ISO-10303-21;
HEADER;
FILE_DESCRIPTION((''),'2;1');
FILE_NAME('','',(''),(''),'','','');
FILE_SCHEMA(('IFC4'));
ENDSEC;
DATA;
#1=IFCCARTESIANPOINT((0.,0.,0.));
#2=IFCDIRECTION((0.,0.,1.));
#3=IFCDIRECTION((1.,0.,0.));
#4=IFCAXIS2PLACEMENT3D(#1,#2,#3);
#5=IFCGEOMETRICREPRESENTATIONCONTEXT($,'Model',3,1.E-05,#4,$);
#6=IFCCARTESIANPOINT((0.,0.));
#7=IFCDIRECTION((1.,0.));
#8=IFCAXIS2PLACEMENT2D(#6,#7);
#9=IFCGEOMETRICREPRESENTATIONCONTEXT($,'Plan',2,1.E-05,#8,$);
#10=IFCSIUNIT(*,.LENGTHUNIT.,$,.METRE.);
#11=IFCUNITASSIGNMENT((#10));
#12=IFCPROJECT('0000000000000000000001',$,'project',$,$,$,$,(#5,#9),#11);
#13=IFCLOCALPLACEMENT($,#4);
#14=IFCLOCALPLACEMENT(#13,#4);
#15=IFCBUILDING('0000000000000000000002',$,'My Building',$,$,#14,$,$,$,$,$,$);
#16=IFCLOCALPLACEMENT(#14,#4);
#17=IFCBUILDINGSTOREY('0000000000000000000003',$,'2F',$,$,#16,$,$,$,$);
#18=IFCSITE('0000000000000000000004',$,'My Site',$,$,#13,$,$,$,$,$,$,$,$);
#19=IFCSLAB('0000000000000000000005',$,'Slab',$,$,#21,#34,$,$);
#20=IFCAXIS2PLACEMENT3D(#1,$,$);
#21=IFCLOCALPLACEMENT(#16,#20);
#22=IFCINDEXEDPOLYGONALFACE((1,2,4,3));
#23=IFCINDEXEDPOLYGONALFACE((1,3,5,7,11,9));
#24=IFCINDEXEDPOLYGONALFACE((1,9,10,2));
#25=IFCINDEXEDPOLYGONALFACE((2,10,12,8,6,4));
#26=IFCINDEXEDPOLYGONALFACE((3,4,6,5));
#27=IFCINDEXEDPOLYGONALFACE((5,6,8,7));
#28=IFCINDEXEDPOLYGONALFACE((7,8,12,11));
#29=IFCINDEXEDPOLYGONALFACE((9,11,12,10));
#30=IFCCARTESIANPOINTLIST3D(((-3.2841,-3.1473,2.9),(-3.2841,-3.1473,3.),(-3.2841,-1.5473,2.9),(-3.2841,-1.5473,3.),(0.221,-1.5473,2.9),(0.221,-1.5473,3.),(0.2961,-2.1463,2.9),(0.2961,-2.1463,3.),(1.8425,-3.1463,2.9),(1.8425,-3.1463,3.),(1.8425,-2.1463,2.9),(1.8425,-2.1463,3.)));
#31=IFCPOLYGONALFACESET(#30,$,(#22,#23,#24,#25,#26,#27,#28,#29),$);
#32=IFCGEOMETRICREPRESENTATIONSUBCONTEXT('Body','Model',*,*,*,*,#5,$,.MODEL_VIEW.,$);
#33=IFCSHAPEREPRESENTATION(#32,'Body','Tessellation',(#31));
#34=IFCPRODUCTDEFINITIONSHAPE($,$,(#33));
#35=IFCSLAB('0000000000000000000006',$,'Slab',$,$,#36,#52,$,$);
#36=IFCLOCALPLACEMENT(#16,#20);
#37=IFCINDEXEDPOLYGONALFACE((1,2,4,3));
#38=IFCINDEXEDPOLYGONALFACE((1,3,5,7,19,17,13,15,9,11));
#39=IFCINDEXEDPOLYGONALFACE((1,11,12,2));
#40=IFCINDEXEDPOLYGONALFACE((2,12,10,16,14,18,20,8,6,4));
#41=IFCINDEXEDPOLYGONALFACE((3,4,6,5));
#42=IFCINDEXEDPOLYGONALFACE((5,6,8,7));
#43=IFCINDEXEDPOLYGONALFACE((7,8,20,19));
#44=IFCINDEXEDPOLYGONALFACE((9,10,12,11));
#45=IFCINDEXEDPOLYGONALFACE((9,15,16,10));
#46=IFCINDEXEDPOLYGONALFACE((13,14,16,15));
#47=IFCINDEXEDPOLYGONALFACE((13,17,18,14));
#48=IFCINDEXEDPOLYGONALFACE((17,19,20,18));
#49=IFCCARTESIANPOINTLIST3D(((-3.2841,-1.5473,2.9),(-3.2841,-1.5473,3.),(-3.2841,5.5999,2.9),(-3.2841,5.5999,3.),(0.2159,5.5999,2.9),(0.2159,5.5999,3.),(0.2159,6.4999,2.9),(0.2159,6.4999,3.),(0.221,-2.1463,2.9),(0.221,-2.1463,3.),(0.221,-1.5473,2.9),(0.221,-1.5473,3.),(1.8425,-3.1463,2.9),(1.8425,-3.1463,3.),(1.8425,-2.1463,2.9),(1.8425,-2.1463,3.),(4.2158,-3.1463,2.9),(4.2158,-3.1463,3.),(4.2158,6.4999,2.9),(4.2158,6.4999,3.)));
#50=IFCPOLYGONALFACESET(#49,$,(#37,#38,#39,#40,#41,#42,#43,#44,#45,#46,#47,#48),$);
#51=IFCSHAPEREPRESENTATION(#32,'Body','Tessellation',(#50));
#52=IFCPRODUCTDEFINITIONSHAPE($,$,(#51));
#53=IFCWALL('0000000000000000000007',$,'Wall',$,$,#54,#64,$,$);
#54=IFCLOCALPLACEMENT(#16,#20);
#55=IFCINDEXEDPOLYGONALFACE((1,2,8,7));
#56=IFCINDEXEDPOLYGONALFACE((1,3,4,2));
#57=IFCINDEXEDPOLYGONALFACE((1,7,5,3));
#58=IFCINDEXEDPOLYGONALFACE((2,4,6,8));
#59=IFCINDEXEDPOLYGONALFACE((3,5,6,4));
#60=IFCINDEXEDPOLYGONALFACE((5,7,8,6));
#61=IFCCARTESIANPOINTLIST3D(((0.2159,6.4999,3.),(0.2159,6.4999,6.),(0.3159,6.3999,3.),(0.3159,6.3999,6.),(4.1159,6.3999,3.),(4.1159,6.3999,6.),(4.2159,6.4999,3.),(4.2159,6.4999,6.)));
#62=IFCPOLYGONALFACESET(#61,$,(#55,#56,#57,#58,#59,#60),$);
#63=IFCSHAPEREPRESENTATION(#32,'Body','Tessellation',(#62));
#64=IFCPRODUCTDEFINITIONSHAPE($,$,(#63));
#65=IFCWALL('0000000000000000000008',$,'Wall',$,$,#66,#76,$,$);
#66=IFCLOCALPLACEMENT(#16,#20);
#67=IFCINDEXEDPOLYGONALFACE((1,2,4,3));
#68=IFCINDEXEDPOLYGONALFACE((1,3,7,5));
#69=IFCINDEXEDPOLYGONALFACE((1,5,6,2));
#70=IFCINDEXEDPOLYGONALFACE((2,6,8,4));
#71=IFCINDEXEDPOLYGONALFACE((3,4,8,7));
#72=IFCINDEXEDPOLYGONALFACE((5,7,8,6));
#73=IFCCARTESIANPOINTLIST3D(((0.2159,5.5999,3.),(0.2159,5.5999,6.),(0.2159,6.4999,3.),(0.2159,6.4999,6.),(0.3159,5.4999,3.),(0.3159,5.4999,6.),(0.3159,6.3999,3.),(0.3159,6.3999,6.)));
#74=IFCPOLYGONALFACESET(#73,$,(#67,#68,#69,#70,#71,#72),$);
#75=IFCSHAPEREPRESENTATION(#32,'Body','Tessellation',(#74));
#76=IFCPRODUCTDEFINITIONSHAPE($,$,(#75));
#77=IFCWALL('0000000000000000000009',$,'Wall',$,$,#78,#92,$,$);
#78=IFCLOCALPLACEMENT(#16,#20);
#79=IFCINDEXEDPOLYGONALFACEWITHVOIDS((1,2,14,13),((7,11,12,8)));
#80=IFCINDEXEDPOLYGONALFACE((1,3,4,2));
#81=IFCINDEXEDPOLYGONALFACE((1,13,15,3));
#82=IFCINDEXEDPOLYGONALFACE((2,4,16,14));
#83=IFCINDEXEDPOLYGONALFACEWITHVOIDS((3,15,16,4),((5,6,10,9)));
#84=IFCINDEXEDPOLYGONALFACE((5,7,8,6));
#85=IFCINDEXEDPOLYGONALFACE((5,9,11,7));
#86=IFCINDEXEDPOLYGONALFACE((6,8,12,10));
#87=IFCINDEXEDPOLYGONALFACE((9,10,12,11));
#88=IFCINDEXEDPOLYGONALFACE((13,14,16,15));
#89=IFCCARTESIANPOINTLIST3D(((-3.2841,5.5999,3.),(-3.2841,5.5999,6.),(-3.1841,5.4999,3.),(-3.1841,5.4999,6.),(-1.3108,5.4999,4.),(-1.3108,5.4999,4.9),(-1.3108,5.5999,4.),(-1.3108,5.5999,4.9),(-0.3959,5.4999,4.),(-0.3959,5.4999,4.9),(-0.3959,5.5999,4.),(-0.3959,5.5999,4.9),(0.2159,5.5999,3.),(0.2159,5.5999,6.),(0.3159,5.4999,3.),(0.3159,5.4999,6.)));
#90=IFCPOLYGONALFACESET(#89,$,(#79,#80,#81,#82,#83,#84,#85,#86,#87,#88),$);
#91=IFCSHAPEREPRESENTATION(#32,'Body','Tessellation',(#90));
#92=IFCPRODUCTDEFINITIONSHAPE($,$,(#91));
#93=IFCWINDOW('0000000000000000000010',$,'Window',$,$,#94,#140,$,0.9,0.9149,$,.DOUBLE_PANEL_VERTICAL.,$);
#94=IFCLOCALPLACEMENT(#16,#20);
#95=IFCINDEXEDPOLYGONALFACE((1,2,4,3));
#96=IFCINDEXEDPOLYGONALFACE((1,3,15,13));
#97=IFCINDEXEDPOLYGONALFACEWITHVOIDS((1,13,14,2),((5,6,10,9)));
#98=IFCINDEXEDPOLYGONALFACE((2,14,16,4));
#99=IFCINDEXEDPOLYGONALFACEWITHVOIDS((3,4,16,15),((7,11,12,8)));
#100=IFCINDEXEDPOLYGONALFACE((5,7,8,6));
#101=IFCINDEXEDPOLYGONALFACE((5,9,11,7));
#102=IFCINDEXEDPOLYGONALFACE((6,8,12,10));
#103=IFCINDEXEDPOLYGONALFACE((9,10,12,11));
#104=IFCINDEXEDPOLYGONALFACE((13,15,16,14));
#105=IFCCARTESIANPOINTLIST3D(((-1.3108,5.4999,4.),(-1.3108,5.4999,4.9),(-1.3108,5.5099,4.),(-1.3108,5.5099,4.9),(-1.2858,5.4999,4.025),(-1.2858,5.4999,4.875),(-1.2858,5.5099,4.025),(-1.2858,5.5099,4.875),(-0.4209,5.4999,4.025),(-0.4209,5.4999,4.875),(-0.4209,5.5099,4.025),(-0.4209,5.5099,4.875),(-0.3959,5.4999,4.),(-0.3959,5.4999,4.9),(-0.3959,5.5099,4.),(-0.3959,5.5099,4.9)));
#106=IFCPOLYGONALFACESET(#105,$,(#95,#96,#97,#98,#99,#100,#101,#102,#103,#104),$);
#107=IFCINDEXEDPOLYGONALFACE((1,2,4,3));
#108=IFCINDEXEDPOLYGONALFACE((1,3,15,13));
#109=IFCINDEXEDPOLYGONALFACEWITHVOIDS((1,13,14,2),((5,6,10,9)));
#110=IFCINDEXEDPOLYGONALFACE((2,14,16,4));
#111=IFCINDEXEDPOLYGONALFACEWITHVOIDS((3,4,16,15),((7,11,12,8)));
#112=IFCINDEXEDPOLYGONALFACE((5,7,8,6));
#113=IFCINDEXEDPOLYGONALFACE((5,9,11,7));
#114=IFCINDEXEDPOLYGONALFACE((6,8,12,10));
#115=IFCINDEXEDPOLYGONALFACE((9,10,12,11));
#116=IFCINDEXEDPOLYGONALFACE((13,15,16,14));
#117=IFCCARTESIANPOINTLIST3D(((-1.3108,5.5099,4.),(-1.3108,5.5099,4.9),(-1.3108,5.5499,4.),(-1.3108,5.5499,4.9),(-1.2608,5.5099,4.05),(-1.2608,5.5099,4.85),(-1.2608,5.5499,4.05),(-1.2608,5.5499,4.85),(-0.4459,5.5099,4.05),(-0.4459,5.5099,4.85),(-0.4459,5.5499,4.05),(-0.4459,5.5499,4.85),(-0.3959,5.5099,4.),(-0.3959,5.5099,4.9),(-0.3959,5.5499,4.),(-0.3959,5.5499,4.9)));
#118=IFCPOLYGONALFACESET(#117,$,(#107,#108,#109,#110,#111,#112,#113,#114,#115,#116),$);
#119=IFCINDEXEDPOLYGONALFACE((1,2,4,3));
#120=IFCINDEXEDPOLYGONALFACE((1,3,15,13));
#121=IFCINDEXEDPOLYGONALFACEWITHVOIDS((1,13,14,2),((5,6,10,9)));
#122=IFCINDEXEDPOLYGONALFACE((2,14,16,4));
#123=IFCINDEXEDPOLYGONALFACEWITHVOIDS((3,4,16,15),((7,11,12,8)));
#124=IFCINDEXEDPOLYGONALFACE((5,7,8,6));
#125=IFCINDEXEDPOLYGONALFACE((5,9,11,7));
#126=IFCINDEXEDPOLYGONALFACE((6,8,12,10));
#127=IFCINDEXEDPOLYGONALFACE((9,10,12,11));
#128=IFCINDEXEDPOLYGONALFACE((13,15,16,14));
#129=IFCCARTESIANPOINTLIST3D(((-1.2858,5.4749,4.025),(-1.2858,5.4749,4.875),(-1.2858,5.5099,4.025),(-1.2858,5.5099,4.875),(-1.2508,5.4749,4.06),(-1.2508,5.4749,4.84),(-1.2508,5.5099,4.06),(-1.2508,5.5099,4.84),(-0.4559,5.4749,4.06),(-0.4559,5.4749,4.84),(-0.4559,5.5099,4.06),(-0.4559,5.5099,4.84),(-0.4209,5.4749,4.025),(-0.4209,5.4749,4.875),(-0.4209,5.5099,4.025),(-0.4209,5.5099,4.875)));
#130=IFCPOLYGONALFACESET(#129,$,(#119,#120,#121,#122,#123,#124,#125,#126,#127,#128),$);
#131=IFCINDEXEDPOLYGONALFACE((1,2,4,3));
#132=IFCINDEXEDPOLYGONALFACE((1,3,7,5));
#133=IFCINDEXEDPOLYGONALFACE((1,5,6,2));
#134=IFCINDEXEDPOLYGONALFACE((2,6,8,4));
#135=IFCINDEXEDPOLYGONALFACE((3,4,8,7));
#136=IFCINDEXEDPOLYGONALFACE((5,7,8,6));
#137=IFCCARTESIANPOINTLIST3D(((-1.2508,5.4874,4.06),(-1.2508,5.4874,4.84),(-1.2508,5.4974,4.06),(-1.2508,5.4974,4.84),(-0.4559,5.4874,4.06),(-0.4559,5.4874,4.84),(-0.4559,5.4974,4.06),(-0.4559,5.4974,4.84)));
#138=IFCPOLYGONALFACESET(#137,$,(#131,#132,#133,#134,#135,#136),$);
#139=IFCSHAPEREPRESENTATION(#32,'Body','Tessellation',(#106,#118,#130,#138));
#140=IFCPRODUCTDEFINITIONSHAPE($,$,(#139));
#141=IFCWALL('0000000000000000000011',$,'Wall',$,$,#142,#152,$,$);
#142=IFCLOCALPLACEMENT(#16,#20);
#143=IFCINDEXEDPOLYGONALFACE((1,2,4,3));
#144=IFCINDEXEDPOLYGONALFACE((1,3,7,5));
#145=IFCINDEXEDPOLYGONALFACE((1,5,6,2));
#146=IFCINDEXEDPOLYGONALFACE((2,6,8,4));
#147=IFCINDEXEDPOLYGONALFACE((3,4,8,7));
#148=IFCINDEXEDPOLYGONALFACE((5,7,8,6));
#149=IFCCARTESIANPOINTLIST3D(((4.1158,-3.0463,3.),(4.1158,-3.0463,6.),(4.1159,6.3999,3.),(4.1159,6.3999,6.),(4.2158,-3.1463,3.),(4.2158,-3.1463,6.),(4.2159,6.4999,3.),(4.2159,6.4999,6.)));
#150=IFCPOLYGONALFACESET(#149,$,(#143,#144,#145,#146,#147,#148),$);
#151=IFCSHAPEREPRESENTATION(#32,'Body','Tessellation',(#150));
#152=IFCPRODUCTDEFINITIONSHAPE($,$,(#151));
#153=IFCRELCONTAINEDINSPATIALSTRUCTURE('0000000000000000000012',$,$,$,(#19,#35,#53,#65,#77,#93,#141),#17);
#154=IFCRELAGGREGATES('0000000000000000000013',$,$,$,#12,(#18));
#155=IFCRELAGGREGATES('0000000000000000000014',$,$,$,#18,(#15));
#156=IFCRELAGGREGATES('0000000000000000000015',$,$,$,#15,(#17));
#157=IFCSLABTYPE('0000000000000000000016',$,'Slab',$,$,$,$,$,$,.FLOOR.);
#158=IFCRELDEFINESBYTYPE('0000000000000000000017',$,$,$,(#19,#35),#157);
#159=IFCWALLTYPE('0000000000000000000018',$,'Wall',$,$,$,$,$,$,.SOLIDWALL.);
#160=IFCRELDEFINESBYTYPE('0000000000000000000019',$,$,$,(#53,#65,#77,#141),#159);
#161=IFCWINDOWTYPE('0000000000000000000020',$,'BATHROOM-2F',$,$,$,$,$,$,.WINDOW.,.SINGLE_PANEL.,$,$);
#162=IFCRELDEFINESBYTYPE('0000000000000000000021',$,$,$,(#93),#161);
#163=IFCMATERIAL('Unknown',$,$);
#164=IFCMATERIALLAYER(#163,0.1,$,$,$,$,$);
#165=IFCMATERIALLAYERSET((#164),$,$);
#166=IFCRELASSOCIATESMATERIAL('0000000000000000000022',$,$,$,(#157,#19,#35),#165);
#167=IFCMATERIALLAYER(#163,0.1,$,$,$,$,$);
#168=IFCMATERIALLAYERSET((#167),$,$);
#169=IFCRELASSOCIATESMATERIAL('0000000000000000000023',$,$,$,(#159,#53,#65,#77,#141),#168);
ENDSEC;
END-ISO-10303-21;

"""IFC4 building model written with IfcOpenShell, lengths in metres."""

from ifc_helpers import new_model, entity, si_unit, frame, origin_with_axes, origin_2d_with_axis, place, context, subcontext, project, spatial, line, indexed_curve, outline, extrude, shape, source, transform, mapped, material, layer, layer_set, layer_usage, type_object, type_shapes, element, fill, save


model = new_model("IFC4")

# Units and contexts
model_context = context("Model", 3, precision=1e-05, world=origin_with_axes())
plan_context = context("Plan", 2, precision=1e-05, world=origin_2d_with_axis())
body_context_1 = subcontext(model_context, "Body", "Model", "MODEL_VIEW")
body_context_2 = subcontext(plan_context, "Body", "Plan", "PLAN_VIEW")
ifc_project = project(units=[si_unit("LENGTHUNIT", "METRE")], contexts=[model_context, plan_context])

# Site, building, storey
site_placement = place(None, origin_with_axes())
site = spatial("IfcSite", under=ifc_project, at=site_placement, Name="My Site")
building_placement = place(site_placement, origin_with_axes())
building = spatial("IfcBuilding", under=site, at=building_placement, Name="My Building")
storey_placement = place(building_placement, origin_with_axes())
storey = spatial("IfcBuildingStorey", under=building, at=storey_placement, Name="2F")

# Slabs
ifc_material = material(Name="Unknown")
ifc_layer_1 = layer(ifc_material, 0.1)
ifc_layer_set_1 = layer_set([ifc_layer_1])
ifc_layer_usage_1 = layer_usage(ifc_layer_set_1, "AXIS3", "POSITIVE", -0.1)
slab_type = type_object("IfcSlabType", Name="Slab", PredefinedType="FLOOR", material=ifc_layer_set_1)
slab_1_placement = place(storey_placement, frame((-3.2841, -1.5473, 3.0), z_axis=(0.0, 0.0, 1.0), x_axis=(1.0, 0.0, 0.0)))
element("IfcSlab", 1, at=slab_1_placement, inside=storey, type_object=slab_type, material=ifc_layer_usage_1, Name="Slab", context=body_context_1, shape_type="SweptSolid", body=[
    extrude(outline(indexed_curve([(0.0, 0.0), (0.0, -1.6), (5.1266, -1.599), (5.1266, -0.599), (3.5803, -0.599), (3.5052, 0.0), (0.0, 0.0)])), frame((0.0, 0.0, -0.1), z_axis=(0.0, 0.0, 1.0), x_axis=(1.0, 0.0, 0.0)), (0.0, 0.0, 1.0), 0.1),
])
ifc_layer_usage_2 = layer_usage(ifc_layer_set_1, "AXIS3", "POSITIVE", -0.1)
slab_2_placement = place(storey_placement, frame((4.2158, 6.4999, 3.0), z_axis=(0.0, 0.0, 1.0), x_axis=(1.0, 0.0, 0.0)))
element("IfcSlab", 2, at=slab_2_placement, inside=storey, type_object=slab_type, material=ifc_layer_usage_2, Name="Slab", context=body_context_1, shape_type="SweptSolid", body=[
    extrude(outline(indexed_curve([(0.0, 0.0), (-4.0, 0.0), (-4.0, -0.9), (-7.5, -0.9), (-7.5, -8.0471), (-3.9948, -8.0471), (-3.9948, -8.6461), (-2.3734, -8.6461), (-2.3734, -9.6461), (0.0, -9.6461), (0.0, 0.0)])), frame((0.0, 0.0, -0.1), z_axis=(0.0, 0.0, 1.0), x_axis=(1.0, 0.0, 0.0)), (0.0, 0.0, 1.0), 0.1),
])

# Walls
ifc_layer_2 = layer(ifc_material, 0.1)
ifc_layer_set_2 = layer_set([ifc_layer_2])
ifc_layer_usage_3 = layer_usage(ifc_layer_set_2, "AXIS2", "POSITIVE", 0.0)
wall_type = type_object("IfcWallType", Name="Wall", PredefinedType="SOLIDWALL", material=ifc_layer_set_2)
wall_1_placement = place(storey_placement, frame((4.2159, 6.4999, 3.0), z_axis=(0.0, 0.0, 1.0), x_axis=(-1.0, 0.0, 0.0)))
element("IfcWall", 3, at=wall_1_placement, inside=storey, type_object=wall_type, material=ifc_layer_usage_3, Name="Wall", context=body_context_1, shape_type="SweptSolid", body=[
    extrude(outline(indexed_curve([(0.0, 0.0), (0.1, 0.1), (3.9, 0.1), (4.0, 0.0)], segments=[line(1, 2, 3, 4, 1)])), origin_with_axes(), (0.0, 0.0, 1.0), 3.0),
])
ifc_layer_usage_4 = layer_usage(ifc_layer_set_2, "AXIS2", "POSITIVE", 0.0)
wall_2_placement = place(storey_placement, frame((0.2159, 6.4999, 3.0), z_axis=(0.0, 0.0, 1.0), x_axis=(0.0, -1.0, 0.0)))
element("IfcWall", 4, at=wall_2_placement, inside=storey, type_object=wall_type, material=ifc_layer_usage_4, Name="Wall", context=body_context_1, shape_type="SweptSolid", body=[
    extrude(outline(indexed_curve([(0.0, 0.0), (0.1, 0.1), (1.0, 0.1), (0.9, 0.0)], segments=[line(1, 2, 3, 4, 1)])), origin_with_axes(), (0.0, 0.0, 1.0), 3.0),
])

# Wall, opening, window
ifc_layer_usage_5 = layer_usage(ifc_layer_set_2, "AXIS2", "POSITIVE", 0.0)
wall_3_placement = place(storey_placement, frame((0.2159, 5.5999, 3.0), z_axis=(0.0, 0.0, 1.0), x_axis=(-1.0, 0.0, 0.0)))
wall_3 = element("IfcWall", 5, at=wall_3_placement, inside=storey, type_object=wall_type, material=ifc_layer_usage_5, Name="Wall", context=body_context_1, shape_type="SweptSolid", body=[
    extrude(outline(indexed_curve([(0.0, 0.0), (-0.1, 0.1), (3.4, 0.1), (3.5, 0.0)], segments=[line(1, 2, 3, 4, 1)])), origin_with_axes(), (0.0, 0.0, 1.0), 3.0),
])
shared_shape_1 = source(origin_with_axes(), body_context_1, "Body", "SweptSolid", [
    extrude(outline(indexed_curve([(0.0, 0.0), (0.9149, 0.0), (0.9149, 0.9), (0.0, 0.9)], segments=[line(1, 2, 3, 4, 1)])), frame((0.0, -0.6, 0.0), z_axis=(0.0, -1.0, 0.0), x_axis=(1.0, 0.0, 0.0)), (0.0, 0.0, -1.0), 1.2),
])
opening_1_placement = place(wall_3_placement, frame((0.6117, 0.0, 1.0), z_axis=(0.0, 0.0, 1.0), x_axis=(1.0, -0.000001, 0.0)))
opening_1 = element("IfcOpeningElement", 6, at=opening_1_placement, cuts=wall_3, PredefinedType="OPENING", context=body_context_1, shape_type="MappedRepresentation", body=[
    mapped(shared_shape_1, transform((0.0, 0.0, 0.0), x_axis=(1.0, 0.0, 0.0), y_axis=(0.0, 1.0, 0.0), z_axis=(0.0, 0.0, 1.0), scale=1.0)),
])
window_type_1 = type_object("IfcWindowType", Name="BATHROOM-2F", PartitioningType="SINGLE_PANEL", PredefinedType="WINDOW")
shared_shape_2 = source(origin_with_axes(), body_context_1, "Body", "SweptSolid", [
    extrude(outline(indexed_curve([(0.0, 0.0), (0.9149, 0.0), (0.9149, 0.9), (0.0, 0.9)], segments=[line(1, 2, 3, 4, 1)]), holes=[indexed_curve([(0.025, 0.025), (0.8899, 0.025), (0.8899, 0.875), (0.025, 0.875)], segments=[line(1, 2, 3, 4, 1)])]), frame((0.0, 0.09, 0.0), z_axis=(0.0, -1.0, 0.0), x_axis=(1.0, 0.0, 0.0)), (0.0, 0.0, -1.0), 0.01),
    extrude(outline(indexed_curve([(0.0, 0.0), (0.9149, 0.0), (0.9149, 0.9), (0.0, 0.9)], segments=[line(1, 2, 3, 4, 1)]), holes=[indexed_curve([(0.05, 0.05), (0.8649, 0.05), (0.8649, 0.85), (0.05, 0.85)], segments=[line(1, 2, 3, 4, 1)])]), frame((0.0, 0.05, 0.0), z_axis=(0.0, -1.0, 0.0), x_axis=(1.0, 0.0, 0.0)), (0.0, 0.0, -1.0), 0.04),
    extrude(outline(indexed_curve([(0.0, 0.0), (0.8649, 0.0), (0.8649, 0.85), (0.0, 0.85)], segments=[line(1, 2, 3, 4, 1)]), holes=[indexed_curve([(0.035, 0.035), (0.8299, 0.035), (0.8299, 0.815), (0.035, 0.815)], segments=[line(1, 2, 3, 4, 1)])]), frame((0.025, 0.09, 0.025), z_axis=(0.0, -1.0, 0.0), x_axis=(1.0, 0.0, 0.0)), (0.0, 0.0, -1.0), 0.035),
    extrude(outline(indexed_curve([(0.035, 0.035), (0.8299, 0.035), (0.8299, 0.815), (0.035, 0.815)], segments=[line(1, 2, 3, 4, 1)])), frame((0.025, 0.1025, 0.025), z_axis=(0.0, -1.0, 0.0), x_axis=(1.0, 0.0, 0.0)), (0.0, 0.0, -1.0), 0.01),
])
shared_shape_3 = source(origin_with_axes(), body_context_2, "Body", "Curve2D", [
    entity("IfcIndexedPolyCurve", entity("IfcCartesianPointList2D", [[0.05, 0.05], [0.8649, 0.05]])),
    entity("IfcIndexedPolyCurve", entity("IfcCartesianPointList2D", [[0.0, 0.1], [0.025, 0.1], [0.025, 0.09], [0.05, 0.09], [0.05, 0.05], [0.0, 0.05]]), [entity("IfcLineIndex", [1, 2, 3, 4, 5, 6, 1])]),
    entity("IfcIndexedPolyCurve", entity("IfcCartesianPointList2D", [[0.9149, 0.1], [0.8899, 0.1], [0.8899, 0.09], [0.8649, 0.09], [0.8649, 0.05], [0.9149, 0.05]]), [entity("IfcLineIndex", [1, 2, 3, 4, 5, 6, 1])]),
    entity("IfcIndexedPolyCurve", entity("IfcCartesianPointList2D", [[0.025, 0.09], [0.06, 0.09], [0.06, 0.125], [0.025, 0.125]]), [entity("IfcLineIndex", [1, 2, 3, 4, 1])]),
    entity("IfcIndexedPolyCurve", entity("IfcCartesianPointList2D", [[0.8899, 0.09], [0.8549, 0.09], [0.8549, 0.125], [0.8899, 0.125]]), [entity("IfcLineIndex", [1, 2, 3, 4, 1])]),
    entity("IfcIndexedPolyCurve", entity("IfcCartesianPointList2D", [[0.06, 0.09], [0.8549, 0.09]])),
    entity("IfcIndexedPolyCurve", entity("IfcCartesianPointList2D", [[0.06, 0.125], [0.8549, 0.125]])),
    entity("IfcIndexedPolyCurve", entity("IfcCartesianPointList2D", [[0.06, 0.1075], [0.8549, 0.1075]])),
])
type_shapes(window_type_1, [shared_shape_2, shared_shape_3])
window_1_placement = place(opening_1_placement, frame((0.0, 0.0, 0.0), z_axis=(0.0, 0.0, 1.0), x_axis=(1.0, 0.0, 0.0)))
window_1 = element("IfcWindow", 7, at=window_1_placement, inside=storey, type_object=window_type_1, Name="Window", OverallHeight=0.9, OverallWidth=0.9149, PartitioningType="DOUBLE_PANEL_VERTICAL", shapes=[
    shape(body_context_1, "Body", "MappedRepresentation", [mapped(shared_shape_2, transform((0.0, 0.0, 0.0), x_axis=(1.0, 0.0, 0.0), y_axis=(0.0, 1.0, 0.0), z_axis=(0.0, 0.0, 1.0), scale=1.0))]),
    shape(body_context_2, "Body", "MappedRepresentation", [mapped(shared_shape_3, transform((0.0, 0.0, 0.0), x_axis=(1.0, 0.0, 0.0), y_axis=(0.0, 1.0, 0.0), z_axis=(0.0, 0.0, 1.0), scale=1.0))]),
])
fill(opening_1, window_1)

# Wall
ifc_layer_usage_6 = layer_usage(ifc_layer_set_2, "AXIS2", "POSITIVE", 0.0)
wall_4_placement = place(storey_placement, frame((4.2158, -3.1463, 3.0), z_axis=(0.0, 0.0, 1.0), x_axis=(0.0, 1.0, 0.0)))
element("IfcWall", 8, at=wall_4_placement, inside=storey, type_object=wall_type, material=ifc_layer_usage_6, Name="Wall", context=body_context_1, shape_type="SweptSolid", body=[
    extrude(outline(indexed_curve([(0.0, 0.0), (0.1, 0.1), (9.5461, 0.1), (9.6461, 0.0)], segments=[line(1, 2, 3, 4, 1)])), origin_with_axes(), (0.0, 0.0, 1.0), 3.0),
])

save(model, "model.ifc")
